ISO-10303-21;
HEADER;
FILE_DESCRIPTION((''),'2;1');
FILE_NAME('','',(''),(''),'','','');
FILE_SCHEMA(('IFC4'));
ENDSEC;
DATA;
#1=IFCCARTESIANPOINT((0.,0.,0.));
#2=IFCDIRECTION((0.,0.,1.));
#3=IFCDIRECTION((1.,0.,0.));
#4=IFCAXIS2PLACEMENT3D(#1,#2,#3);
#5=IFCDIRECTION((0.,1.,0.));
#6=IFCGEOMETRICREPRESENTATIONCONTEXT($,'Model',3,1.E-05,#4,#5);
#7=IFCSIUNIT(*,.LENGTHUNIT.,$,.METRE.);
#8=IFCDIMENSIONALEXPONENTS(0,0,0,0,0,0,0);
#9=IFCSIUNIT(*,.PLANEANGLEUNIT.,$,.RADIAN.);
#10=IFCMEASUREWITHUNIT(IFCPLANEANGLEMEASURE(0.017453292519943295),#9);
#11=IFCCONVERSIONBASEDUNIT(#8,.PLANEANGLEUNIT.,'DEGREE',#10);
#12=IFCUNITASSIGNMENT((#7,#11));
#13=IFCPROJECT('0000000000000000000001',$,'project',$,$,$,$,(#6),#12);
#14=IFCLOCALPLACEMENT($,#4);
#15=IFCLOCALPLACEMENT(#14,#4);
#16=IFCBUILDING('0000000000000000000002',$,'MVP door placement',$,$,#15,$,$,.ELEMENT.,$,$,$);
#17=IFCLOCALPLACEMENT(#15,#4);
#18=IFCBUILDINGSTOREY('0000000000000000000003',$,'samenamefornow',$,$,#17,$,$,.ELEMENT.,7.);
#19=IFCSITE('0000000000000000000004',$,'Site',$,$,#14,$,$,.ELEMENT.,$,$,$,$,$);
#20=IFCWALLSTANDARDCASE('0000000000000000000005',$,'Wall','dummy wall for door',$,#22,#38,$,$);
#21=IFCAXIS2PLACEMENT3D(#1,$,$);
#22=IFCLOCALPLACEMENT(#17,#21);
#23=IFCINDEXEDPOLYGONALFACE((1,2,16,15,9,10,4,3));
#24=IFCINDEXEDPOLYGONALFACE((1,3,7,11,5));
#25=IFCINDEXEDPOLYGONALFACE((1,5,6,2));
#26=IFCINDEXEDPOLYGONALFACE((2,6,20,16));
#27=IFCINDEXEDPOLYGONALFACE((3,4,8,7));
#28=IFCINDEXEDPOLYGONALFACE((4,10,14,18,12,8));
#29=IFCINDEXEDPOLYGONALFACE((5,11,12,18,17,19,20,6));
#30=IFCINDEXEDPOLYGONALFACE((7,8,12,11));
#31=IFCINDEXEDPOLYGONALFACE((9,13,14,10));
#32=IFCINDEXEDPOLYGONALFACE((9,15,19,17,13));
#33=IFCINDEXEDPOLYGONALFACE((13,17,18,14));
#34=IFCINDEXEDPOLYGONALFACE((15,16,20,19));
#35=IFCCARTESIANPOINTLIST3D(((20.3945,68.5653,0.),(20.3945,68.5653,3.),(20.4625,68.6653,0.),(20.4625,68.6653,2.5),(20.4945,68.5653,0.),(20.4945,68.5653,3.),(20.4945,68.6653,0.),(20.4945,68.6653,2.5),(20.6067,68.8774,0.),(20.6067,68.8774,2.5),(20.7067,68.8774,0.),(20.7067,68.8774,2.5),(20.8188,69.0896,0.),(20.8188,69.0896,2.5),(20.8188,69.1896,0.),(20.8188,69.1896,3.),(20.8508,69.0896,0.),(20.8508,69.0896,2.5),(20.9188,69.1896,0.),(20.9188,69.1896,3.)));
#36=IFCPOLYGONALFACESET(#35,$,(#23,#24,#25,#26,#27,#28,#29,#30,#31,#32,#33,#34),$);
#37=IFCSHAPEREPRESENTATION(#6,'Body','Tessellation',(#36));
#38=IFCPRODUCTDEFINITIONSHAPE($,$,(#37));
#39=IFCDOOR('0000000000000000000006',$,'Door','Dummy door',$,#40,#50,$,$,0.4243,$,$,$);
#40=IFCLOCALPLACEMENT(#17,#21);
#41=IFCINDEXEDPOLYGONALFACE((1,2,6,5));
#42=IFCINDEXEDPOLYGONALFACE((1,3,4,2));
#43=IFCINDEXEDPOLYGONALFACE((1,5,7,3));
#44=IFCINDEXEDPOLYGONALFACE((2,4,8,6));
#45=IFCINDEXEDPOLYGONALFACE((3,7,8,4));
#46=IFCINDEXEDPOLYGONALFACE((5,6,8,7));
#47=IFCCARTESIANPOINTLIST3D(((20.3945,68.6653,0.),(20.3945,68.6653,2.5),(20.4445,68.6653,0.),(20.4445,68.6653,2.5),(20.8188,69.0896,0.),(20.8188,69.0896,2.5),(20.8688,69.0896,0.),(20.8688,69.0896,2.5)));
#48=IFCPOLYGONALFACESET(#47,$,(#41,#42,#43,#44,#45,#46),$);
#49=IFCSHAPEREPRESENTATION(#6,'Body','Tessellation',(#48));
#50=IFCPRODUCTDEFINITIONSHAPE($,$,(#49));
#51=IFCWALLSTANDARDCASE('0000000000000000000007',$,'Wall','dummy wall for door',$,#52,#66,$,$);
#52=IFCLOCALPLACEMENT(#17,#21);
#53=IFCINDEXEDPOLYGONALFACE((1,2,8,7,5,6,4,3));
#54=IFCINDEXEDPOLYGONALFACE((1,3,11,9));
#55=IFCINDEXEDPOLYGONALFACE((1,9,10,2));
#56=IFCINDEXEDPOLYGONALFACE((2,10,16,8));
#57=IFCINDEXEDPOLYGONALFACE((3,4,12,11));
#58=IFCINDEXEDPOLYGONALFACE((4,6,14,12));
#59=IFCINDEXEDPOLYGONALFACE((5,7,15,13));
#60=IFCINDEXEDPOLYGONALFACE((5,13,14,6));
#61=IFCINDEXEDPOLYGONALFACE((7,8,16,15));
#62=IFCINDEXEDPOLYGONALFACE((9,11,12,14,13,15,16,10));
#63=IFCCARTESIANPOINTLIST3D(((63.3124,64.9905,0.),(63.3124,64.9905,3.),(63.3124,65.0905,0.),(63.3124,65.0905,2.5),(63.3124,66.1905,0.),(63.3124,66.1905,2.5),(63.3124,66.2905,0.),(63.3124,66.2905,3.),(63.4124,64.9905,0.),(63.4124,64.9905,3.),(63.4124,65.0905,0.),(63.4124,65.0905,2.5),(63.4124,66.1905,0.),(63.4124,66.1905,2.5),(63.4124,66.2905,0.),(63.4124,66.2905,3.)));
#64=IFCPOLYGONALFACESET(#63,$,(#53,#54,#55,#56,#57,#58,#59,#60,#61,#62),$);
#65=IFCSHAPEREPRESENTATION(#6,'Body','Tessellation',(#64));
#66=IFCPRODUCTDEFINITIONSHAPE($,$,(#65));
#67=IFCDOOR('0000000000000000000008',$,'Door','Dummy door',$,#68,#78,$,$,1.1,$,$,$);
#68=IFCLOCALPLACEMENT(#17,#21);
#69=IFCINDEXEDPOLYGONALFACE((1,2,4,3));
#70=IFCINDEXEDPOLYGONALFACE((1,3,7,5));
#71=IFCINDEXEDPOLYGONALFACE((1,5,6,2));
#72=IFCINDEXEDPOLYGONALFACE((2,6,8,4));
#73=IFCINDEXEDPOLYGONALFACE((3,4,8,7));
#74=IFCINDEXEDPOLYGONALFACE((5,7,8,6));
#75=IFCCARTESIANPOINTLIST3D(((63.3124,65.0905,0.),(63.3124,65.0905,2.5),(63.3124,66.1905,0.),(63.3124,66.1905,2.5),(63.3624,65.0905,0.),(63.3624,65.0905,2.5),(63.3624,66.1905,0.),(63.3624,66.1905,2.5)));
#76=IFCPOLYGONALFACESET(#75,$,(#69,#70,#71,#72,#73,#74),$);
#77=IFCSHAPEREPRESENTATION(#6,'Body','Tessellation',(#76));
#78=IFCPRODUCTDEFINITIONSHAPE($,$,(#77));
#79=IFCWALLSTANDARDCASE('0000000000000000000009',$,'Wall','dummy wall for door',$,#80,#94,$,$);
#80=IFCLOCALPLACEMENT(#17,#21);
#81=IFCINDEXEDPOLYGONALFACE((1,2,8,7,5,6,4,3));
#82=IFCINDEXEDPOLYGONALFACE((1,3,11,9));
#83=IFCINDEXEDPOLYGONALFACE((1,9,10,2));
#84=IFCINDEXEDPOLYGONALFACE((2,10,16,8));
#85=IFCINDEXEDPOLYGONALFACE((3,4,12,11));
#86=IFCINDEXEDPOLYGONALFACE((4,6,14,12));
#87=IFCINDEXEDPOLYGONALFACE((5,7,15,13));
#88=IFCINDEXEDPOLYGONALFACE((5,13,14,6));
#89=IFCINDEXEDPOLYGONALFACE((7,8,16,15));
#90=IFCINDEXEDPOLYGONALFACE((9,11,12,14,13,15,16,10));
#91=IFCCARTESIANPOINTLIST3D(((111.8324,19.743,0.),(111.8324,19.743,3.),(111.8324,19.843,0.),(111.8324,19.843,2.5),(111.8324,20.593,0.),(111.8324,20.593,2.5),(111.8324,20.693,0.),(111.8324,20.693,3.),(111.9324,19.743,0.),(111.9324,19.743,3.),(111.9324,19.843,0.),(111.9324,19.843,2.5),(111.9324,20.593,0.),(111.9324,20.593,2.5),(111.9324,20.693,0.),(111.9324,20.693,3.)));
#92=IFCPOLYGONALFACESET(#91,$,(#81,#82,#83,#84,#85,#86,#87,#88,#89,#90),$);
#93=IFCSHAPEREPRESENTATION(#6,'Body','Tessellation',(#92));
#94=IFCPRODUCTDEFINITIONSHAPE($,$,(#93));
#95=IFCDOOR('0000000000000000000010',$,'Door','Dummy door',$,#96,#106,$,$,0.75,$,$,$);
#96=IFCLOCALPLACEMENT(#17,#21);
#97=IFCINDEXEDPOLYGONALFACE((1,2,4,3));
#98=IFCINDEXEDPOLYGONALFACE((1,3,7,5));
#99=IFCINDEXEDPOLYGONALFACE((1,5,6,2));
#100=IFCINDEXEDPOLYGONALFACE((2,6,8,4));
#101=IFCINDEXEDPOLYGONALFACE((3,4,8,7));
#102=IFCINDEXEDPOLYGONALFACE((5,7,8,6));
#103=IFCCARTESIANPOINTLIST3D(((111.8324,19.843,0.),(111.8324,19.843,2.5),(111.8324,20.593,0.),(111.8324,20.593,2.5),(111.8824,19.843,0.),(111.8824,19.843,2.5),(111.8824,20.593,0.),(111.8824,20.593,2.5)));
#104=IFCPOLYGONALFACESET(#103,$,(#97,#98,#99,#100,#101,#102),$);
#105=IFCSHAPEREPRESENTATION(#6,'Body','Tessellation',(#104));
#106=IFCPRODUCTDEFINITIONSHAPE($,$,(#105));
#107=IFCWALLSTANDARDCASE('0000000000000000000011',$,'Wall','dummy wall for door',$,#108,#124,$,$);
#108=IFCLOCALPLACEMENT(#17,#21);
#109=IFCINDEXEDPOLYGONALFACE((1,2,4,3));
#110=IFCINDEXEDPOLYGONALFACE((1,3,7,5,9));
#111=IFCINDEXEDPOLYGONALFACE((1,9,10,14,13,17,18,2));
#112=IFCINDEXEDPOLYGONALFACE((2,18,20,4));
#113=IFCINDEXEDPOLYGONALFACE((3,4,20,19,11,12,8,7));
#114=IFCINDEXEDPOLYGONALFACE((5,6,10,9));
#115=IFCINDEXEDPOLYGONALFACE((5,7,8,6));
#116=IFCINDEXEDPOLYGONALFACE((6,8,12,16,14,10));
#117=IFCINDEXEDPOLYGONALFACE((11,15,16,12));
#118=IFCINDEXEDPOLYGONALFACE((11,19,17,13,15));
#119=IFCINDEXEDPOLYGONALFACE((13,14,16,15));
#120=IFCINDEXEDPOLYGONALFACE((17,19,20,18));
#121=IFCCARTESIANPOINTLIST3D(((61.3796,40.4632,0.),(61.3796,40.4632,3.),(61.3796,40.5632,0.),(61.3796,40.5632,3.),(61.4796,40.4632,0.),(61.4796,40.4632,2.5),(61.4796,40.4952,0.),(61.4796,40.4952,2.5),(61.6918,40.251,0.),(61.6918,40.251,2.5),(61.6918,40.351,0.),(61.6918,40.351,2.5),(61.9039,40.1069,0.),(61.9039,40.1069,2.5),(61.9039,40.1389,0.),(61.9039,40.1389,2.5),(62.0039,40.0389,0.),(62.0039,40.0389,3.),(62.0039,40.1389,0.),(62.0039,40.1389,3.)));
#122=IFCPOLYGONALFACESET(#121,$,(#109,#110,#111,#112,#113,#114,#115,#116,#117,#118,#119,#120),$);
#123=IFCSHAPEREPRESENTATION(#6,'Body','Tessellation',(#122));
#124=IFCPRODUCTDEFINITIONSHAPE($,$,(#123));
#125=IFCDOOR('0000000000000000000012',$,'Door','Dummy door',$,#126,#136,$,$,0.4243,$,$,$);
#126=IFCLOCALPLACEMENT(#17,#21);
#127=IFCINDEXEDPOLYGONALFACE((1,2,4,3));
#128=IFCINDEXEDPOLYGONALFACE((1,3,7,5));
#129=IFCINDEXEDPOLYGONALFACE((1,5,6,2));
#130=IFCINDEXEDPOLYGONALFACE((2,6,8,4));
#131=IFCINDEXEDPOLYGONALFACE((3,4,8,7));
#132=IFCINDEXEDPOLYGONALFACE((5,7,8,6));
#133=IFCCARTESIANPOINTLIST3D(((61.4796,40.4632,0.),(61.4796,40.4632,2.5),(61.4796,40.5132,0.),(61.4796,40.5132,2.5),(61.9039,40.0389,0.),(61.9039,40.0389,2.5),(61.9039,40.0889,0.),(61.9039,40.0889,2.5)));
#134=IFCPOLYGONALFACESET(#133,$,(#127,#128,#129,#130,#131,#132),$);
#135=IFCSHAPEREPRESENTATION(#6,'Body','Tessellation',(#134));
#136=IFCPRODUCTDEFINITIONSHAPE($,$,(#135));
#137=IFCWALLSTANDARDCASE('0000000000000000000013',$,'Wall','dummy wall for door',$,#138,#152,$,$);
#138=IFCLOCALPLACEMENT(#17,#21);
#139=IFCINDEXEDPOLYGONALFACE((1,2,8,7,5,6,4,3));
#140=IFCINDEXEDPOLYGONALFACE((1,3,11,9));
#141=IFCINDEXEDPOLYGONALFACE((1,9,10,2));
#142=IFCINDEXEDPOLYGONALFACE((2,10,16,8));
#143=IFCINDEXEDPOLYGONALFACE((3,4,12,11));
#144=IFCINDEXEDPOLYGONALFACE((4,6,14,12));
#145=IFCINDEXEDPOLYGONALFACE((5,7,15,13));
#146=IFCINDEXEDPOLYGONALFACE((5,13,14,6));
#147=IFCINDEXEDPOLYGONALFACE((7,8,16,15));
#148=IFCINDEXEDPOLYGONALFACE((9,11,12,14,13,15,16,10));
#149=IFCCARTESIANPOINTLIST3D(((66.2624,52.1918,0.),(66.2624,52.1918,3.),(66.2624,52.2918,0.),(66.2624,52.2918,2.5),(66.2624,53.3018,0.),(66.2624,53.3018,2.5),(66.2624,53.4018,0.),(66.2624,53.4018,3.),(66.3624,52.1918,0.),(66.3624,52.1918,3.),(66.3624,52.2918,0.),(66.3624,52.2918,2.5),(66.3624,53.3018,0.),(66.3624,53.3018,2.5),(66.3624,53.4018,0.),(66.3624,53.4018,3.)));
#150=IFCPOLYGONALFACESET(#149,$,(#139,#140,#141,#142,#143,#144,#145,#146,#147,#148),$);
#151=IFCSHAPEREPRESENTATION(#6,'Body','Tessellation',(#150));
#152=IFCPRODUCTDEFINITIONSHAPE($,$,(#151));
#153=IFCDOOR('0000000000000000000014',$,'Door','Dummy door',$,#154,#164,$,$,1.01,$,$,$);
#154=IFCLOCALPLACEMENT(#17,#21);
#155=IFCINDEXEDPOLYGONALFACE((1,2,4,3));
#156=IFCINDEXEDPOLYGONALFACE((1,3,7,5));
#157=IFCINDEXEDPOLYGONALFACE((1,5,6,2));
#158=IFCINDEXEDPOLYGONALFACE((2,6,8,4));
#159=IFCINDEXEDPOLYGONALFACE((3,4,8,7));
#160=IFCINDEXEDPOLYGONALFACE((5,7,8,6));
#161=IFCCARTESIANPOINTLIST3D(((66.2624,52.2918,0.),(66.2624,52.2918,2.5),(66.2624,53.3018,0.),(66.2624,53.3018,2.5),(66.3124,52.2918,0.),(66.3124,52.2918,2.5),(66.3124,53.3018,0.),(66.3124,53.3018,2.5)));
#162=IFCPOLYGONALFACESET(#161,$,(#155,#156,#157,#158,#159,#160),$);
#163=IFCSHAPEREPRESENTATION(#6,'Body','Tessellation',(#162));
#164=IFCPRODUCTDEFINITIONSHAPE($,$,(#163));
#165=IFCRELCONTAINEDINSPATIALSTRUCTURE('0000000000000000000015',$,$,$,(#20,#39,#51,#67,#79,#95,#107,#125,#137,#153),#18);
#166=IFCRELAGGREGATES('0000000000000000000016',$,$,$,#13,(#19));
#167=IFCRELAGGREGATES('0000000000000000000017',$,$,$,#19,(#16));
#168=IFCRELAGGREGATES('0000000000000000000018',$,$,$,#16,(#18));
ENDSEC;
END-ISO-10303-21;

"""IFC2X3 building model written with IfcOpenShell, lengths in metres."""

from ifc_helpers import new_model, entity, si_unit, converted_unit, direction, origin_with_axes, place, context, project, spatial, polyline, outline, extrude, element, fill, save


model = new_model("IFC2X3")

# Units and contexts
model_context = context("Model", 3, precision=1e-05, world=origin_with_axes(), true_north=direction((0.0, 1.0, 0.0)))
ifc_project = project(units=[si_unit("LENGTHUNIT", "METRE"), converted_unit("PLANEANGLEUNIT", "DEGREE", entity("IfcPlaneAngleMeasure", 0.017453292519943295), si_unit("PLANEANGLEUNIT", "RADIAN"), dimensions=[0, 0, 0, 0, 0, 0, 0])], contexts=[model_context])

# Site, building, storey
site_placement = place(None, origin_with_axes())
site = spatial("IfcSite", under=ifc_project, at=site_placement, Name="Site", CompositionType="ELEMENT")
building_placement = place(site_placement, origin_with_axes())
building = spatial("IfcBuilding", under=site, at=building_placement, Name="MVP door placement", CompositionType="ELEMENT")
storey_placement = place(building_placement, origin_with_axes())
storey = spatial("IfcBuildingStorey", under=building, at=storey_placement, Name="samenamefornow", CompositionType="ELEMENT", Elevation=7.0)

# Walls, openings, doors
wall_1_placement = place(storey_placement, origin_with_axes())
wall_1 = element("IfcWallStandardCase", 1, at=wall_1_placement, inside=storey, Name="Wall", Description="dummy wall for door", context=model_context, shape_type="SweptSolid", body=[
    extrude(outline(polyline([(20.8188, 69.1896, 0.0), (20.3945, 68.5653, 0.0), (20.4945, 68.5653, 0.0), (20.9188, 69.1896, 0.0), (20.8188, 69.1896, 0.0)])), origin_with_axes(), (0.0, 0.0, 1.0), 3.0),
])
opening_1_placement = place(wall_1_placement, origin_with_axes())
opening_1 = element("IfcOpeningElement", 2, at=opening_1_placement, cuts=wall_1, context=model_context, shape_type="SweptSolid", body=[
    extrude(outline(polyline([(20.8188, 69.0896, 0.0), (20.3945, 68.6653, 0.0), (20.4945, 68.6653, 0.0), (20.9188, 69.0896, 0.0), (20.8188, 69.0896, 0.0)])), origin_with_axes(), (0.0, 0.0, 1.0), 2.5),
])
door_1_placement = place(opening_1_placement, origin_with_axes())
door_1 = element("IfcDoor", 3, at=door_1_placement, inside=storey, Name="Door", Description="Dummy door", OverallWidth=0.4243, context=model_context, shape_type="SweptSolid", body=[
    extrude(outline(polyline([(20.8188, 69.0896, 0.0), (20.3945, 68.6653, 0.0), (20.4445, 68.6653, 0.0), (20.8688, 69.0896, 0.0), (20.8188, 69.0896, 0.0)])), origin_with_axes(), (0.0, 0.0, 1.0), 2.5),
])
fill(opening_1, door_1)
wall_2_placement = place(storey_placement, origin_with_axes())
wall_2 = element("IfcWallStandardCase", 4, at=wall_2_placement, inside=storey, Name="Wall", Description="dummy wall for door", context=model_context, shape_type="SweptSolid", body=[
    extrude(outline(polyline([(63.3124, 64.9905, 0.0), (63.3124, 66.2905, 0.0), (63.4124, 66.2905, 0.0), (63.4124, 64.9905, 0.0), (63.3124, 64.9905, 0.0)])), origin_with_axes(), (0.0, 0.0, 1.0), 3.0),
])
opening_2_placement = place(wall_2_placement, origin_with_axes())
opening_2 = element("IfcOpeningElement", 5, at=opening_2_placement, cuts=wall_2, context=model_context, shape_type="SweptSolid", body=[
    extrude(outline(polyline([(63.3124, 65.0905, 0.0), (63.3124, 66.1905, 0.0), (63.4124, 66.1905, 0.0), (63.4124, 65.0905, 0.0), (63.3124, 65.0905, 0.0)])), origin_with_axes(), (0.0, 0.0, 1.0), 2.5),
])
door_2_placement = place(opening_2_placement, origin_with_axes())
door_2 = element("IfcDoor", 6, at=door_2_placement, inside=storey, Name="Door", Description="Dummy door", OverallWidth=1.1, context=model_context, shape_type="SweptSolid", body=[
    extrude(outline(polyline([(63.3124, 65.0905, 0.0), (63.3124, 66.1905, 0.0), (63.3624, 66.1905, 0.0), (63.3624, 65.0905, 0.0), (63.3124, 65.0905, 0.0)])), origin_with_axes(), (0.0, 0.0, 1.0), 2.5),
])
fill(opening_2, door_2)
wall_3_placement = place(storey_placement, origin_with_axes())
wall_3 = element("IfcWallStandardCase", 7, at=wall_3_placement, inside=storey, Name="Wall", Description="dummy wall for door", context=model_context, shape_type="SweptSolid", body=[
    extrude(outline(polyline([(111.8324, 20.693, 0.0), (111.8324, 19.743, 0.0), (111.9324, 19.743, 0.0), (111.9324, 20.693, 0.0), (111.8324, 20.693, 0.0)])), origin_with_axes(), (0.0, 0.0, 1.0), 3.0),
])
opening_3_placement = place(wall_3_placement, origin_with_axes())
opening_3 = element("IfcOpeningElement", 8, at=opening_3_placement, cuts=wall_3, context=model_context, shape_type="SweptSolid", body=[
    extrude(outline(polyline([(111.8324, 20.593, 0.0), (111.8324, 19.843, 0.0), (111.9324, 19.843, 0.0), (111.9324, 20.593, 0.0), (111.8324, 20.593, 0.0)])), origin_with_axes(), (0.0, 0.0, 1.0), 2.5),
])
door_3_placement = place(opening_3_placement, origin_with_axes())
door_3 = element("IfcDoor", 9, at=door_3_placement, inside=storey, Name="Door", Description="Dummy door", OverallWidth=0.75, context=model_context, shape_type="SweptSolid", body=[
    extrude(outline(polyline([(111.8324, 20.593, 0.0), (111.8324, 19.843, 0.0), (111.8824, 19.843, 0.0), (111.8824, 20.593, 0.0), (111.8324, 20.593, 0.0)])), origin_with_axes(), (0.0, 0.0, 1.0), 2.5),
])
fill(opening_3, door_3)
wall_4_placement = place(storey_placement, origin_with_axes())
wall_4 = element("IfcWallStandardCase", 10, at=wall_4_placement, inside=storey, Name="Wall", Description="dummy wall for door", context=model_context, shape_type="SweptSolid", body=[
    extrude(outline(polyline([(61.3796, 40.4632, 0.0), (62.0039, 40.0389, 0.0), (62.0039, 40.1389, 0.0), (61.3796, 40.5632, 0.0), (61.3796, 40.4632, 0.0)])), origin_with_axes(), (0.0, 0.0, 1.0), 3.0),
])
opening_4_placement = place(wall_4_placement, origin_with_axes())
opening_4 = element("IfcOpeningElement", 11, at=opening_4_placement, cuts=wall_4, context=model_context, shape_type="SweptSolid", body=[
    extrude(outline(polyline([(61.4796, 40.4632, 0.0), (61.9039, 40.0389, 0.0), (61.9039, 40.1389, 0.0), (61.4796, 40.5632, 0.0), (61.4796, 40.4632, 0.0)])), origin_with_axes(), (0.0, 0.0, 1.0), 2.5),
])
door_4_placement = place(opening_4_placement, origin_with_axes())
door_4 = element("IfcDoor", 12, at=door_4_placement, inside=storey, Name="Door", Description="Dummy door", OverallWidth=0.4243, context=model_context, shape_type="SweptSolid", body=[
    extrude(outline(polyline([(61.4796, 40.4632, 0.0), (61.9039, 40.0389, 0.0), (61.9039, 40.0889, 0.0), (61.4796, 40.5132, 0.0), (61.4796, 40.4632, 0.0)])), origin_with_axes(), (0.0, 0.0, 1.0), 2.5),
])
fill(opening_4, door_4)
wall_5_placement = place(storey_placement, origin_with_axes())
wall_5 = element("IfcWallStandardCase", 13, at=wall_5_placement, inside=storey, Name="Wall", Description="dummy wall for door", context=model_context, shape_type="SweptSolid", body=[
    extrude(outline(polyline([(66.2624, 52.1918, 0.0), (66.2624, 53.4018, 0.0), (66.3624, 53.4018, 0.0), (66.3624, 52.1918, 0.0), (66.2624, 52.1918, 0.0)])), origin_with_axes(), (0.0, 0.0, 1.0), 3.0),
])
opening_5_placement = place(wall_5_placement, origin_with_axes())
opening_5 = element("IfcOpeningElement", 14, at=opening_5_placement, cuts=wall_5, context=model_context, shape_type="SweptSolid", body=[
    extrude(outline(polyline([(66.2624, 52.2918, 0.0), (66.2624, 53.3018, 0.0), (66.3624, 53.3018, 0.0), (66.3624, 52.2918, 0.0), (66.2624, 52.2918, 0.0)])), origin_with_axes(), (0.0, 0.0, 1.0), 2.5),
])
door_5_placement = place(opening_5_placement, origin_with_axes())
door_5 = element("IfcDoor", 15, at=door_5_placement, inside=storey, Name="Door", Description="Dummy door", OverallWidth=1.01, context=model_context, shape_type="SweptSolid", body=[
    extrude(outline(polyline([(66.2624, 52.2918, 0.0), (66.2624, 53.3018, 0.0), (66.3124, 53.3018, 0.0), (66.3124, 52.2918, 0.0), (66.2624, 52.2918, 0.0)])), origin_with_axes(), (0.0, 0.0, 1.0), 2.5),
])
fill(opening_5, door_5)

save(model, "model.ifc")
